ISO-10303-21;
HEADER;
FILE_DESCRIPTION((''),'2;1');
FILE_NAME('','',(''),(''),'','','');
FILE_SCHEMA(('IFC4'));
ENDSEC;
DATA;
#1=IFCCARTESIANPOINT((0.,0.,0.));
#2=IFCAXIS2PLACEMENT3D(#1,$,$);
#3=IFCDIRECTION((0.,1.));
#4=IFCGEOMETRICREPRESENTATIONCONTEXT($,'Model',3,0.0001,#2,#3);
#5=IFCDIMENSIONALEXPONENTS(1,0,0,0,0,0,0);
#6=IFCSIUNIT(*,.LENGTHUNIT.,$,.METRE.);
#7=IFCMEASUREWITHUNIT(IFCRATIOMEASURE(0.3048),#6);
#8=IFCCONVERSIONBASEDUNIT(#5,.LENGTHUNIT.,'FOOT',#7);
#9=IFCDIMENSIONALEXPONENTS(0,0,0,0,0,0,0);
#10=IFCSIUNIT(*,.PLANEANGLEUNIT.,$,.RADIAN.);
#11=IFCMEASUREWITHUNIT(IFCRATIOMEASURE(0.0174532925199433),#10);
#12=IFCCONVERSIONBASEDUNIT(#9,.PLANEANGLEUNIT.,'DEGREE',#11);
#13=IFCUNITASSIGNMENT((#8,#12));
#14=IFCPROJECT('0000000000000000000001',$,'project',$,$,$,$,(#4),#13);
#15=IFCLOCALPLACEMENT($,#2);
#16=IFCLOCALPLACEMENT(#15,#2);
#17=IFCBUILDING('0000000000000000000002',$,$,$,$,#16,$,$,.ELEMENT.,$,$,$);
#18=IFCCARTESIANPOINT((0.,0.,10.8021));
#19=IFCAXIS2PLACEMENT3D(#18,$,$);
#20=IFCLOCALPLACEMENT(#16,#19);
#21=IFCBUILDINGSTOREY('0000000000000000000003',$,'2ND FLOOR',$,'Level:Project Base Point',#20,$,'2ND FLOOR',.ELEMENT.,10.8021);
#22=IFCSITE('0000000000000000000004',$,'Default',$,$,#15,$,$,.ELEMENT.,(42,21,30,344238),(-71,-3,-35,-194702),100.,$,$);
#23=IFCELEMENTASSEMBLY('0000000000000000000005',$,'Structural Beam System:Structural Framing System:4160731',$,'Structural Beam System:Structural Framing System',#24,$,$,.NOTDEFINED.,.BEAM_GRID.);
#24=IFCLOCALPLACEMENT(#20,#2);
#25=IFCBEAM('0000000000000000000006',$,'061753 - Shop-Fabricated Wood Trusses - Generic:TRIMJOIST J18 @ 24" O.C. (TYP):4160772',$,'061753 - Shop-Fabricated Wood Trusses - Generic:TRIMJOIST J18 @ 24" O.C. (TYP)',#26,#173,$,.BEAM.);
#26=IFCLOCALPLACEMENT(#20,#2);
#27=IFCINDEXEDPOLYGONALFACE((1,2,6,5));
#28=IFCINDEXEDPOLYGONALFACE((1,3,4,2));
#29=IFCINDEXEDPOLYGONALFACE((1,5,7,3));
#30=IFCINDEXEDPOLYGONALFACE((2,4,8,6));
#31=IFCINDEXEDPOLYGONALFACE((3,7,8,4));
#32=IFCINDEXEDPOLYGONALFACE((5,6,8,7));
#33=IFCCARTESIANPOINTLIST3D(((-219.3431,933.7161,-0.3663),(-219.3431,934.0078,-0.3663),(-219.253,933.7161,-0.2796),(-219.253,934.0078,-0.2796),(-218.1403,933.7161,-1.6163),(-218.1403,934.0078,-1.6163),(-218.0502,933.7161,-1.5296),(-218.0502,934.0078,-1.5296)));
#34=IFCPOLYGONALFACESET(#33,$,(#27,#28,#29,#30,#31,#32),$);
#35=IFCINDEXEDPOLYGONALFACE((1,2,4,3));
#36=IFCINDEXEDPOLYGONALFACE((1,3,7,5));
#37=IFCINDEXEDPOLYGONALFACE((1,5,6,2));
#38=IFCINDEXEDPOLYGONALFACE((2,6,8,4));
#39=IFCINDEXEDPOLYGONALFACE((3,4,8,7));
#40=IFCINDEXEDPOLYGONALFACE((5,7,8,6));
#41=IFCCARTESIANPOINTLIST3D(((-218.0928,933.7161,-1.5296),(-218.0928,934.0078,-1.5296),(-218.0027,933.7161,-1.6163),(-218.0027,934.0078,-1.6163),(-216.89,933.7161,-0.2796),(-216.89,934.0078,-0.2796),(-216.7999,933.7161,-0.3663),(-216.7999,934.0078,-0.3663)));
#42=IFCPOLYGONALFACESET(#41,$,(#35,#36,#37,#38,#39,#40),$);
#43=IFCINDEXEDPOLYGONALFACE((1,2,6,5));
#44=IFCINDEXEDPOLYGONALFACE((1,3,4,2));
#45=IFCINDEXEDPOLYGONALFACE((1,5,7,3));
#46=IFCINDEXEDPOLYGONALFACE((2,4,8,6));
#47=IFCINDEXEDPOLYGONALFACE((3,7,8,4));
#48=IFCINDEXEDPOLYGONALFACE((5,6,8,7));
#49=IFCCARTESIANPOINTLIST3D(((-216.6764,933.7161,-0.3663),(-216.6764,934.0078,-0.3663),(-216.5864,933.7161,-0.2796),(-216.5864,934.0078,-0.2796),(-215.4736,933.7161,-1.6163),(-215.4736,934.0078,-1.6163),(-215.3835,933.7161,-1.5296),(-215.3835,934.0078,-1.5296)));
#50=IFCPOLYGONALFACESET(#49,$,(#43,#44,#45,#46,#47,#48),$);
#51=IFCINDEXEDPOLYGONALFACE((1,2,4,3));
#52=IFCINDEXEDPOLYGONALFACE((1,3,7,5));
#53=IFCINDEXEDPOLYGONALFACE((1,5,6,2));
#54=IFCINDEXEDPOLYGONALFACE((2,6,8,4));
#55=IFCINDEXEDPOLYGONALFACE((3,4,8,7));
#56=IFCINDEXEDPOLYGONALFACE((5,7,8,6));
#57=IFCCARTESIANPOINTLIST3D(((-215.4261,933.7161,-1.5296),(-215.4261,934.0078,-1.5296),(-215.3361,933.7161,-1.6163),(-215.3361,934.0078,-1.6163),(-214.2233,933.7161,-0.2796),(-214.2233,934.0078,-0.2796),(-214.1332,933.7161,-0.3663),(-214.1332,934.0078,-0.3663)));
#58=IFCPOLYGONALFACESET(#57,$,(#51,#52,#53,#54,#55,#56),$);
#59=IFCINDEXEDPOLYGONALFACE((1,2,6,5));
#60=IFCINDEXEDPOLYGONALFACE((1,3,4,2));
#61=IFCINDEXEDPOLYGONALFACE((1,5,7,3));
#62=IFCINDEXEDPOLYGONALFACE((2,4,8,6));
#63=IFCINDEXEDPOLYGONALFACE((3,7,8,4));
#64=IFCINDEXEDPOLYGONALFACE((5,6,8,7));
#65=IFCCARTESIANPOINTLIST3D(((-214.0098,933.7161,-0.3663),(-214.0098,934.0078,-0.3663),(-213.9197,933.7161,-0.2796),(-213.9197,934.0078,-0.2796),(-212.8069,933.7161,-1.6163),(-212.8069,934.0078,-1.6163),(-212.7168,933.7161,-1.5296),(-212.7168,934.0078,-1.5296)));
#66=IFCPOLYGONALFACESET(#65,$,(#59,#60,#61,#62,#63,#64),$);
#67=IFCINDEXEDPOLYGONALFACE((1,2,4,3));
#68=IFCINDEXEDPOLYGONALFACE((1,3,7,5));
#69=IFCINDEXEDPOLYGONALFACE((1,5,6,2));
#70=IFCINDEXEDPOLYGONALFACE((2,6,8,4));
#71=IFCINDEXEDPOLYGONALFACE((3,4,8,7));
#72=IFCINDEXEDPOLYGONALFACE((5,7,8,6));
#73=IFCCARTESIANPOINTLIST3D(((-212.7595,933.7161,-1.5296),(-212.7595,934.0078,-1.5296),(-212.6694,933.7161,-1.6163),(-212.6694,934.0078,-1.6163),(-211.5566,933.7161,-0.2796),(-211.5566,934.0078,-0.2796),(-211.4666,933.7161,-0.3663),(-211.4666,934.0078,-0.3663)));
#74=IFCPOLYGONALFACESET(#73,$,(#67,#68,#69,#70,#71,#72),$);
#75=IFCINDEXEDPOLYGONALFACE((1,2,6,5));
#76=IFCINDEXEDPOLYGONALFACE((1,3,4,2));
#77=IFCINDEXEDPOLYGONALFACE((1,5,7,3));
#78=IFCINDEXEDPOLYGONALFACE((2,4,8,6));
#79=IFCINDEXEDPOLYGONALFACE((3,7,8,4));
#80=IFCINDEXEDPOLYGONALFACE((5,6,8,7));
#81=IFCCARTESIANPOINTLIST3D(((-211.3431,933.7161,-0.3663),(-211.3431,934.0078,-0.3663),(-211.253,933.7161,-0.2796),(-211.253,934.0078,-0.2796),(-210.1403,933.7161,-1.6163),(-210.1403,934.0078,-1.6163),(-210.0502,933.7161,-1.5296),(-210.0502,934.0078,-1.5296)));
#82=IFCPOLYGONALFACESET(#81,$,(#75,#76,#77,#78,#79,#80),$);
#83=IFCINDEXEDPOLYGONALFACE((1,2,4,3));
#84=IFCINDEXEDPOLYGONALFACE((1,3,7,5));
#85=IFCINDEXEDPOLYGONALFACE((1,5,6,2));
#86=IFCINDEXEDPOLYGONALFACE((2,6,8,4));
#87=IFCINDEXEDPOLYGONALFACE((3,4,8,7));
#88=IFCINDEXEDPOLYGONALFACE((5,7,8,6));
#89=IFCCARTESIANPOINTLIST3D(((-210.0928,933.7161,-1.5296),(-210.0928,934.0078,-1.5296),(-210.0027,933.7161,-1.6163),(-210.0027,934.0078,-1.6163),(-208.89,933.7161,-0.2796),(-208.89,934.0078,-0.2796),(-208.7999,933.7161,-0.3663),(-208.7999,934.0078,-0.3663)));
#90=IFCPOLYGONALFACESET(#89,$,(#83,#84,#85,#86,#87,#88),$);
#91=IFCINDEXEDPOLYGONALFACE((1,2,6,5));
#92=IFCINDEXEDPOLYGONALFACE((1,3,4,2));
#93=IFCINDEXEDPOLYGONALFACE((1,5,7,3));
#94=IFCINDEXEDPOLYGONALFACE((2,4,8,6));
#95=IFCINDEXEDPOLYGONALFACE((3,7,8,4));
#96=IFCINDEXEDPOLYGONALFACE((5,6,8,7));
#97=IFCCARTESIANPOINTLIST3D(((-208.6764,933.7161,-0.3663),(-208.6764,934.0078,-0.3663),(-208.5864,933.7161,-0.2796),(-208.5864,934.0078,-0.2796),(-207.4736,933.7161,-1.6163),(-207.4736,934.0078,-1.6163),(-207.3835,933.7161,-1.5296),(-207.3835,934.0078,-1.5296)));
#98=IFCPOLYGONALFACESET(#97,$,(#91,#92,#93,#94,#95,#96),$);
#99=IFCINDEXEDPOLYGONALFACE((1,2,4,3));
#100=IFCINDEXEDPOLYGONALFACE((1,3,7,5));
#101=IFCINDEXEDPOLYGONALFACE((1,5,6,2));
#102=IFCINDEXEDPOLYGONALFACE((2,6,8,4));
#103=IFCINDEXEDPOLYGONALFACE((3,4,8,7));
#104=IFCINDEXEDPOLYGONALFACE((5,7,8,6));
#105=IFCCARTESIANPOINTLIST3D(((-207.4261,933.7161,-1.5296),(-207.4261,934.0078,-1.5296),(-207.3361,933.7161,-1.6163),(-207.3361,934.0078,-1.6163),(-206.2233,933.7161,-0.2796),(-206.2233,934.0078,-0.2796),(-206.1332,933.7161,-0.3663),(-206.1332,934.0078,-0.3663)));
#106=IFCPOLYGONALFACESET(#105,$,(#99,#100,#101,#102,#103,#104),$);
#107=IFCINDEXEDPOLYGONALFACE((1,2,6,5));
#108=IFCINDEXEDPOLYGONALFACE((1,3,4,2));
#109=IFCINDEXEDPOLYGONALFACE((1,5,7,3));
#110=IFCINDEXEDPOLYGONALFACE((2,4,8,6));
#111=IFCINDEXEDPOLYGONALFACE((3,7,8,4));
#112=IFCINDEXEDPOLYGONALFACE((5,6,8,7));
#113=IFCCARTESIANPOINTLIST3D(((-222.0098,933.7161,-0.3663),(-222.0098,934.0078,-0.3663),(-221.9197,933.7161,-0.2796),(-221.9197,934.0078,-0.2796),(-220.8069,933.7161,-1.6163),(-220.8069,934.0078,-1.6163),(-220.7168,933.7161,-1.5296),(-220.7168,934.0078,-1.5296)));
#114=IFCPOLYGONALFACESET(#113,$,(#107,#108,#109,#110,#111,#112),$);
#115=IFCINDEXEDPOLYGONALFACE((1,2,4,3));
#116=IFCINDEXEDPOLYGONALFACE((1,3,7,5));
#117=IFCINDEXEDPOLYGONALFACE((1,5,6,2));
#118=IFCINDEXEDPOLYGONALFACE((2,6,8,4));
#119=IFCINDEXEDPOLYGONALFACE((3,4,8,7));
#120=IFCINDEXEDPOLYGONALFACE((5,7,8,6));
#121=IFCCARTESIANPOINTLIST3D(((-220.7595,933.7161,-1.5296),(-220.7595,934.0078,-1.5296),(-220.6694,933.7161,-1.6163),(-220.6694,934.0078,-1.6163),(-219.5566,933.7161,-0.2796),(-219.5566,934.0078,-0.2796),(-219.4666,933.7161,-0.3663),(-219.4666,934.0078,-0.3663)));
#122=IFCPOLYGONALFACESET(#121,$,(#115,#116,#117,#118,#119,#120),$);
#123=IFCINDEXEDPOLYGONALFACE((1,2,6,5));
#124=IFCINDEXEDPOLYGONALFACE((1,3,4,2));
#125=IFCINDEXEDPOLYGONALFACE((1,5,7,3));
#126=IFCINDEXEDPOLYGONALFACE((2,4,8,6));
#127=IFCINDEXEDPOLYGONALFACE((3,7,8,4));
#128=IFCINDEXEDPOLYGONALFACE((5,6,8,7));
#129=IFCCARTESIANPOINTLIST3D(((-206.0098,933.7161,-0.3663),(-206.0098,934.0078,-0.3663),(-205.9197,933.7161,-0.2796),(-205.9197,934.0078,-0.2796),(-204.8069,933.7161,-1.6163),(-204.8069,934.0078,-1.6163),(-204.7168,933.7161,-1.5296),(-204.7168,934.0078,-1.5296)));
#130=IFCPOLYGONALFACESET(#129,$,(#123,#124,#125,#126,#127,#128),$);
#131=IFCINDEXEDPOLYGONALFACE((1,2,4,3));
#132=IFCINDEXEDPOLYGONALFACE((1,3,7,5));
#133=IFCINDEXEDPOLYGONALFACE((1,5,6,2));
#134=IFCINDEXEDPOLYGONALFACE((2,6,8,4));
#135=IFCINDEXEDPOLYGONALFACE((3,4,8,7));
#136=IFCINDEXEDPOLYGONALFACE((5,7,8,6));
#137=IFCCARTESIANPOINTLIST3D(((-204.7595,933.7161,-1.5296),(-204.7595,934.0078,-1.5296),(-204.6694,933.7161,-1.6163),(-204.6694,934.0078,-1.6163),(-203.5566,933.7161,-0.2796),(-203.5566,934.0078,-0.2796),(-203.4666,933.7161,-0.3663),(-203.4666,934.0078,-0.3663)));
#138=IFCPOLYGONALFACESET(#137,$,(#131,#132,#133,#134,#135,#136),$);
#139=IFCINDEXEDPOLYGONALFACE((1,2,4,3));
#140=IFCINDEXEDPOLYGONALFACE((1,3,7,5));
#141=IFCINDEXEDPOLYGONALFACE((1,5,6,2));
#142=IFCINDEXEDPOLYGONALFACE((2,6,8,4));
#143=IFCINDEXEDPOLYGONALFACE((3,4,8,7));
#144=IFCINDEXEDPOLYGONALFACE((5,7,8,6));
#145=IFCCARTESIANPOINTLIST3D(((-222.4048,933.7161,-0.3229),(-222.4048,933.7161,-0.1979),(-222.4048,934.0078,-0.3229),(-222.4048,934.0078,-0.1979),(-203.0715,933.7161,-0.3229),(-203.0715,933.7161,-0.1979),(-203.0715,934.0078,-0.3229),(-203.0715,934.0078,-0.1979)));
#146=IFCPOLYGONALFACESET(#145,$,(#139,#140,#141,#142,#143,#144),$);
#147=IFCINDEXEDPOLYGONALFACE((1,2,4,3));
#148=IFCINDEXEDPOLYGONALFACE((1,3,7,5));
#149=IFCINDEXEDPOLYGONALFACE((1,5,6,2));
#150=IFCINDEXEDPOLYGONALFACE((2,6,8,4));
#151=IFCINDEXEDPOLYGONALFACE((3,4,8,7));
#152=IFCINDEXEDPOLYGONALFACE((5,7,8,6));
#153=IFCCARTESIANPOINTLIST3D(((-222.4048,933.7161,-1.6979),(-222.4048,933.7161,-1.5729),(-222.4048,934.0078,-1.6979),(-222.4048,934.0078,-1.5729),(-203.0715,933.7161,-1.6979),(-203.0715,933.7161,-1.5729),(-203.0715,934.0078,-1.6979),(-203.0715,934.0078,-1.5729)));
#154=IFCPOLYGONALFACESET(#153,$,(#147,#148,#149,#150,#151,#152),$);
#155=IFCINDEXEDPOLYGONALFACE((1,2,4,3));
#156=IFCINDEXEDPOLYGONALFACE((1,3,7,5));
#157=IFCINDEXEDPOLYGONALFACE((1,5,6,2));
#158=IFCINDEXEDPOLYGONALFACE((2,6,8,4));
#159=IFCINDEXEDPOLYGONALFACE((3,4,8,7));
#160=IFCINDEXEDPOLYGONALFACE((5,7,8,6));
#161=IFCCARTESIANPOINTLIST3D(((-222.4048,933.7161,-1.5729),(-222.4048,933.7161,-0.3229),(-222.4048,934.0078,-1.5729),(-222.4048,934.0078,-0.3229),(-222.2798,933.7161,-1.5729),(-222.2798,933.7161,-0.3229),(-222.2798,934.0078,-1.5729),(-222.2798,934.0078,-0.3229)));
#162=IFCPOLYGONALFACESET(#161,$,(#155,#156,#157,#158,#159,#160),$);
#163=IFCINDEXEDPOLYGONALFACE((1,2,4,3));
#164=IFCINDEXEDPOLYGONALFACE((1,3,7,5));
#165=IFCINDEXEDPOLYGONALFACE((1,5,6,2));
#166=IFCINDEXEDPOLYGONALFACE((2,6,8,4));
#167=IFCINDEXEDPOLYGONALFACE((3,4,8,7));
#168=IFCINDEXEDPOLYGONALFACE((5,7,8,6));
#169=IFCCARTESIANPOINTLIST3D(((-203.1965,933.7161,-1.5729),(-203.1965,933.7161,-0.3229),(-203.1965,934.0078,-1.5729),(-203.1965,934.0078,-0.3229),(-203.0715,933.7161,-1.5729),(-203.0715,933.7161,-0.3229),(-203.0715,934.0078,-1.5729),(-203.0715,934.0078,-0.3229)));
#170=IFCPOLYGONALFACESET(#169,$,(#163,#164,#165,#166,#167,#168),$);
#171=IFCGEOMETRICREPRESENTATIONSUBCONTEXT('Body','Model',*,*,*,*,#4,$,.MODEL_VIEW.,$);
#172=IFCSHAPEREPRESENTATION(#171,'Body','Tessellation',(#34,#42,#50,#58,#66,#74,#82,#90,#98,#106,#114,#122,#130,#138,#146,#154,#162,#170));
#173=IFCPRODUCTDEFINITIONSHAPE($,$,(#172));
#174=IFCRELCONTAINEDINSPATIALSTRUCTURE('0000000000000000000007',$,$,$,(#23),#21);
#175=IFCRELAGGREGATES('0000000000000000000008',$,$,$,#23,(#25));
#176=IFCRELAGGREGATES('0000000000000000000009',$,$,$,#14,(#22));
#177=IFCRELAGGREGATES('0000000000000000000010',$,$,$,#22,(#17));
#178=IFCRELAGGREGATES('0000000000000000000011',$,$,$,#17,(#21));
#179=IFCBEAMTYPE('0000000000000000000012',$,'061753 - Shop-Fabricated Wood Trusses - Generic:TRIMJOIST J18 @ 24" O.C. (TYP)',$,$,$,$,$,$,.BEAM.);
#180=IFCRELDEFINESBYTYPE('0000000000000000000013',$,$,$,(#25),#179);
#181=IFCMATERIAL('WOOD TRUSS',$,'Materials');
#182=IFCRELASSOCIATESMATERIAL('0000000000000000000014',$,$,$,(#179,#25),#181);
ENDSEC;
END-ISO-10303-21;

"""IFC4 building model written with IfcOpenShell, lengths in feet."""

from ifc_helpers import new_model, entity, si_unit, converted_unit, direction, frame, frame_2d, origin, origin_2d_with_axis, place, context, subcontext, project, spatial, rectangle, extrude, source, transform, mapped, material, material_profile, profile_set, profile_usage, type_object, type_shapes, element, aggregate, save


model = new_model("IFC4")

# Units and contexts
model_context = context("Model", 3, precision=0.0001, world=origin(), true_north=direction((0.0, 1.0)))
body_context = subcontext(model_context, "Body", "Model", "MODEL_VIEW")
ifc_project = project(units=[converted_unit("LENGTHUNIT", "FOOT", entity("IfcRatioMeasure", 0.3048), si_unit("LENGTHUNIT", "METRE"), dimensions=[1, 0, 0, 0, 0, 0, 0]), converted_unit("PLANEANGLEUNIT", "DEGREE", entity("IfcRatioMeasure", 0.0174532925199433), si_unit("PLANEANGLEUNIT", "RADIAN"), dimensions=[0, 0, 0, 0, 0, 0, 0])], contexts=[model_context])

# Site, building, storey
site_placement = place(None, origin())
site = spatial("IfcSite", under=ifc_project, at=site_placement, Name="Default", CompositionType="ELEMENT", RefLatitude=(42, 21, 30, 344238), RefLongitude=(-71, -3, -35, -194702), RefElevation=100.0)
building_placement = place(site_placement, origin())
building = spatial("IfcBuilding", under=site, at=building_placement, CompositionType="ELEMENT")
storey_placement = place(building_placement, frame((0.0, 0.0, 10.8021)))
storey = spatial("IfcBuildingStorey", under=building, at=storey_placement, Name="2ND FLOOR", ObjectType="Level:Project Base Point", LongName="2ND FLOOR", CompositionType="ELEMENT", Elevation=10.8021)

# Element assembly, beam
ifc_material_1 = material(Name="WOOD TRUSS", Category="Materials")
ifc_material_profile_1 = material_profile(ifc_material_1, rectangle(XDim=1.7347, YDim=0.125, at=frame_2d((0.0, 0.0), x_axis=(1.0, 0.0))), Name="TRIMJOIST J18 @ 24\" O.C. (TYP)")
ifc_material_profile_2 = material_profile(ifc_material_1, rectangle(XDim=1.7347, YDim=0.125, at=frame_2d((0.0, 0.0), x_axis=(1.0, 0.0))), Name="TRIMJOIST J18 @ 24\" O.C. (TYP)")
ifc_material_profile_3 = material_profile(ifc_material_1, rectangle(XDim=1.7347, YDim=0.125, at=frame_2d((0.0, 0.0), x_axis=(1.0, 0.0))), Name="TRIMJOIST J18 @ 24\" O.C. (TYP)")
ifc_material_profile_4 = material_profile(ifc_material_1, rectangle(XDim=1.7347, YDim=0.125, at=frame_2d((0.0, 0.0), x_axis=(1.0, 0.0))), Name="TRIMJOIST J18 @ 24\" O.C. (TYP)")
ifc_material_profile_5 = material_profile(ifc_material_1, rectangle(XDim=1.7347, YDim=0.125, at=frame_2d((0.0, 0.0), x_axis=(1.0, 0.0))), Name="TRIMJOIST J18 @ 24\" O.C. (TYP)")
ifc_material_profile_6 = material_profile(ifc_material_1, rectangle(XDim=1.7347, YDim=0.125, at=frame_2d((0.0, 0.0), x_axis=(1.0, 0.0))), Name="TRIMJOIST J18 @ 24\" O.C. (TYP)")
ifc_material_profile_7 = material_profile(ifc_material_1, rectangle(XDim=1.7347, YDim=0.125, at=frame_2d((0.0, 0.0), x_axis=(1.0, 0.0))), Name="TRIMJOIST J18 @ 24\" O.C. (TYP)")
ifc_material_profile_8 = material_profile(ifc_material_1, rectangle(XDim=1.7347, YDim=0.125, at=frame_2d((0.0, 0.0), x_axis=(1.0, 0.0))), Name="TRIMJOIST J18 @ 24\" O.C. (TYP)")
ifc_material_profile_9 = material_profile(ifc_material_1, rectangle(XDim=1.7347, YDim=0.125, at=frame_2d((0.0, 0.0), x_axis=(1.0, 0.0))), Name="TRIMJOIST J18 @ 24\" O.C. (TYP)")
ifc_material_profile_10 = material_profile(ifc_material_1, rectangle(XDim=1.7347, YDim=0.125, at=origin_2d_with_axis()), Name="TRIMJOIST J18 @ 24\" O.C. (TYP)")
ifc_material_profile_11 = material_profile(ifc_material_1, rectangle(XDim=0.125, YDim=0.2917, at=origin_2d_with_axis()), Name="TRIMJOIST J18 @ 24\" O.C. (TYP)")
ifc_material_profile_12 = material_profile(ifc_material_1, rectangle(XDim=0.125, YDim=0.2917, at=origin_2d_with_axis()), Name="TRIMJOIST J18 @ 24\" O.C. (TYP)")
ifc_material_profile_13 = material_profile(ifc_material_1, rectangle(XDim=1.25, YDim=0.2917, at=origin_2d_with_axis()), Name="TRIMJOIST J18 @ 24\" O.C. (TYP)")
ifc_material_profile_14 = material_profile(ifc_material_1, rectangle(XDim=1.25, YDim=0.2917, at=origin_2d_with_axis()), Name="TRIMJOIST J18 @ 24\" O.C. (TYP)")
ifc_profile_set_1 = profile_set([ifc_material_profile_1, ifc_material_profile_2, ifc_material_profile_3, ifc_material_profile_4, ifc_material_profile_5, ifc_material_profile_6, ifc_material_profile_7, ifc_material_profile_8, ifc_material_profile_9, ifc_material_profile_10, ifc_material_profile_11, ifc_material_profile_12, ifc_material_profile_13, ifc_material_profile_14], Name="TRIMJOIST J18 @ 24\" O.C. (TYP)")
beam_type_1 = type_object("IfcBeamType", Name="061753 - Shop-Fabricated Wood Trusses - Generic:TRIMJOIST J18 @ 24\" O.C. (TYP)", PredefinedType="BEAM", material=ifc_profile_set_1)
shared_shape_1 = source(origin(), body_context, "Body", "SweptSolid", [
    extrude(rectangle(XDim=1.7347, YDim=0.125, at=frame_2d((0.0, 0.0), x_axis=(1.0, 0.0))), frame((5.9585, -0.1458, 0.0), z_axis=(0.0, 1.0, 0.0), x_axis=(0.693383, 0.0, 0.720569)), (0.0, 0.0, 1.0), 0.2917),
    extrude(rectangle(XDim=1.7347, YDim=0.125, at=origin_2d_with_axis()), frame((4.7082, -0.1458, 0.0), z_axis=(0.0, 1.0, 0.0), x_axis=(0.693383, 0.0, -0.720569)), (0.0, 0.0, 1.0), 0.2917),
    extrude(rectangle(XDim=1.7347, YDim=0.125, at=frame_2d((0.0, 0.0), x_axis=(1.0, 0.0))), frame((3.2918, -0.1458, 0.0), z_axis=(0.0, 1.0, 0.0), x_axis=(0.693383, 0.0, 0.720569)), (0.0, 0.0, 1.0), 0.2917),
    extrude(rectangle(XDim=1.7347, YDim=0.125, at=frame_2d((0.0, 0.0), x_axis=(1.0, 0.0))), frame((2.0415, -0.1458, 0.0), z_axis=(0.0, 1.0, 0.0), x_axis=(0.693383, 0.0, -0.720569)), (0.0, 0.0, 1.0), 0.2917),
    extrude(rectangle(XDim=1.7347, YDim=0.125, at=frame_2d((0.0, 0.0), x_axis=(1.0, 0.0))), frame((0.6251, -0.1458, 0.0), z_axis=(0.0, 1.0, 0.0), x_axis=(0.693383, 0.0, 0.720569)), (0.0, 0.0, 1.0), 0.2917),
    extrude(rectangle(XDim=1.7347, YDim=0.125, at=frame_2d((0.0, 0.0), x_axis=(1.0, 0.0))), frame((-0.6251, -0.1458, 0.0), z_axis=(0.0, 1.0, 0.0), x_axis=(0.693383, 0.0, -0.720569)), (0.0, 0.0, 1.0), 0.2917),
    extrude(rectangle(XDim=1.7347, YDim=0.125, at=frame_2d((0.0, 0.0), x_axis=(1.0, 0.0))), frame((-2.0415, -0.1458, 0.0), z_axis=(0.0, 1.0, 0.0), x_axis=(0.693383, 0.0, 0.720569)), (0.0, 0.0, 1.0), 0.2917),
    extrude(rectangle(XDim=1.7347, YDim=0.125, at=origin_2d_with_axis()), frame((-3.2918, -0.1458, 0.0), z_axis=(0.0, 1.0, 0.0), x_axis=(0.693383, 0.0, -0.720569)), (0.0, 0.0, 1.0), 0.2917),
    extrude(rectangle(XDim=1.7347, YDim=0.125, at=frame_2d((0.0, 0.0), x_axis=(1.0, 0.0))), frame((-4.7082, -0.1458, 0.0), z_axis=(0.0, 1.0, 0.0), x_axis=(0.693383, 0.0, 0.720569)), (0.0, 0.0, 1.0), 0.2917),
    extrude(rectangle(XDim=1.7347, YDim=0.125, at=frame_2d((0.0, 0.0), x_axis=(1.0, 0.0))), frame((-5.9585, -0.1458, 0.0), z_axis=(0.0, 1.0, 0.0), x_axis=(0.693383, 0.0, -0.720569)), (0.0, 0.0, 1.0), 0.2917),
    extrude(rectangle(XDim=1.7347, YDim=0.125, at=frame_2d((0.0, 0.0), x_axis=(1.0, 0.0))), frame((8.6251, -0.1458, 0.0), z_axis=(0.0, 1.0, 0.0), x_axis=(0.693383, 0.0, 0.720569)), (0.0, 0.0, 1.0), 0.2917),
    extrude(rectangle(XDim=1.7347, YDim=0.125, at=origin_2d_with_axis()), frame((7.3749, -0.1458, 0.0), z_axis=(0.0, 1.0, 0.0), x_axis=(0.693383, 0.0, -0.720569)), (0.0, 0.0, 1.0), 0.2917),
    extrude(rectangle(XDim=1.7347, YDim=0.125, at=frame_2d((0.0, 0.0), x_axis=(1.0, 0.0))), frame((-7.3749, -0.1458, 0.0), z_axis=(0.0, 1.0, 0.0), x_axis=(0.693383, 0.0, 0.720569)), (0.0, 0.0, 1.0), 0.2917),
    extrude(rectangle(XDim=1.7347, YDim=0.125, at=origin_2d_with_axis()), frame((-8.6251, -0.1458, 0.0), z_axis=(0.0, 1.0, 0.0), x_axis=(0.693383, 0.0, -0.720569)), (0.0, 0.0, 1.0), 0.2917),
    extrude(rectangle(XDim=0.125, YDim=0.2917, at=origin_2d_with_axis()), frame((-9.6667, 0.0, 0.6875), z_axis=(1.0, 0.0, 0.0), x_axis=(0.0, 0.0, -1.0)), (0.0, 0.0, 1.0), 19.3333),
    extrude(rectangle(XDim=0.125, YDim=0.2917, at=origin_2d_with_axis()), frame((-9.6667, 0.0, -0.6875), z_axis=(1.0, 0.0, 0.0), x_axis=(0.0, 0.0, -1.0)), (0.0, 0.0, 1.0), 19.3333),
    extrude(rectangle(XDim=1.25, YDim=0.2917, at=origin_2d_with_axis()), frame((9.5417, 0.0, 0.0), z_axis=(1.0, 0.0, 0.0), x_axis=(0.0, 0.0, -1.0)), (0.0, 0.0, 1.0), 0.125),
    extrude(rectangle(XDim=1.25, YDim=0.2917, at=origin_2d_with_axis()), frame((-9.6667, 0.0, 0.0), z_axis=(1.0, 0.0, 0.0), x_axis=(0.0, 0.0, -1.0)), (0.0, 0.0, 1.0), 0.125),
])
type_shapes(beam_type_1, [shared_shape_1])
assembly_1_placement = place(storey_placement, origin())
assembly_1 = element("IfcElementAssembly", 1, at=assembly_1_placement, inside=storey, Name="Structural Beam System:Structural Framing System:4160731", ObjectType="Structural Beam System:Structural Framing System", AssemblyPlace="NOTDEFINED", PredefinedType="BEAM_GRID")
ifc_profile_usage_1 = profile_usage(ifc_profile_set_1, cardinal=8)
beam_1_placement = place(assembly_1_placement, frame((-212.7382, 933.8619, -0.9479), z_axis=(0.0, 0.0, 1.0), x_axis=(-1.0, 0.0, 0.0)))
beam_1 = element("IfcBeam", 2, at=beam_1_placement, type_object=beam_type_1, material=ifc_profile_usage_1, Name="061753 - Shop-Fabricated Wood Trusses - Generic:TRIMJOIST J18 @ 24\" O.C. (TYP):4160772", ObjectType="061753 - Shop-Fabricated Wood Trusses - Generic:TRIMJOIST J18 @ 24\" O.C. (TYP)", PredefinedType="BEAM", context=body_context, shape_type="MappedRepresentation", body=[
    mapped(shared_shape_1, transform((0.0, 0.0, 0.0), scale=1.0)),
])
aggregate(assembly_1, [beam_1])

save(model, "model.ifc")
